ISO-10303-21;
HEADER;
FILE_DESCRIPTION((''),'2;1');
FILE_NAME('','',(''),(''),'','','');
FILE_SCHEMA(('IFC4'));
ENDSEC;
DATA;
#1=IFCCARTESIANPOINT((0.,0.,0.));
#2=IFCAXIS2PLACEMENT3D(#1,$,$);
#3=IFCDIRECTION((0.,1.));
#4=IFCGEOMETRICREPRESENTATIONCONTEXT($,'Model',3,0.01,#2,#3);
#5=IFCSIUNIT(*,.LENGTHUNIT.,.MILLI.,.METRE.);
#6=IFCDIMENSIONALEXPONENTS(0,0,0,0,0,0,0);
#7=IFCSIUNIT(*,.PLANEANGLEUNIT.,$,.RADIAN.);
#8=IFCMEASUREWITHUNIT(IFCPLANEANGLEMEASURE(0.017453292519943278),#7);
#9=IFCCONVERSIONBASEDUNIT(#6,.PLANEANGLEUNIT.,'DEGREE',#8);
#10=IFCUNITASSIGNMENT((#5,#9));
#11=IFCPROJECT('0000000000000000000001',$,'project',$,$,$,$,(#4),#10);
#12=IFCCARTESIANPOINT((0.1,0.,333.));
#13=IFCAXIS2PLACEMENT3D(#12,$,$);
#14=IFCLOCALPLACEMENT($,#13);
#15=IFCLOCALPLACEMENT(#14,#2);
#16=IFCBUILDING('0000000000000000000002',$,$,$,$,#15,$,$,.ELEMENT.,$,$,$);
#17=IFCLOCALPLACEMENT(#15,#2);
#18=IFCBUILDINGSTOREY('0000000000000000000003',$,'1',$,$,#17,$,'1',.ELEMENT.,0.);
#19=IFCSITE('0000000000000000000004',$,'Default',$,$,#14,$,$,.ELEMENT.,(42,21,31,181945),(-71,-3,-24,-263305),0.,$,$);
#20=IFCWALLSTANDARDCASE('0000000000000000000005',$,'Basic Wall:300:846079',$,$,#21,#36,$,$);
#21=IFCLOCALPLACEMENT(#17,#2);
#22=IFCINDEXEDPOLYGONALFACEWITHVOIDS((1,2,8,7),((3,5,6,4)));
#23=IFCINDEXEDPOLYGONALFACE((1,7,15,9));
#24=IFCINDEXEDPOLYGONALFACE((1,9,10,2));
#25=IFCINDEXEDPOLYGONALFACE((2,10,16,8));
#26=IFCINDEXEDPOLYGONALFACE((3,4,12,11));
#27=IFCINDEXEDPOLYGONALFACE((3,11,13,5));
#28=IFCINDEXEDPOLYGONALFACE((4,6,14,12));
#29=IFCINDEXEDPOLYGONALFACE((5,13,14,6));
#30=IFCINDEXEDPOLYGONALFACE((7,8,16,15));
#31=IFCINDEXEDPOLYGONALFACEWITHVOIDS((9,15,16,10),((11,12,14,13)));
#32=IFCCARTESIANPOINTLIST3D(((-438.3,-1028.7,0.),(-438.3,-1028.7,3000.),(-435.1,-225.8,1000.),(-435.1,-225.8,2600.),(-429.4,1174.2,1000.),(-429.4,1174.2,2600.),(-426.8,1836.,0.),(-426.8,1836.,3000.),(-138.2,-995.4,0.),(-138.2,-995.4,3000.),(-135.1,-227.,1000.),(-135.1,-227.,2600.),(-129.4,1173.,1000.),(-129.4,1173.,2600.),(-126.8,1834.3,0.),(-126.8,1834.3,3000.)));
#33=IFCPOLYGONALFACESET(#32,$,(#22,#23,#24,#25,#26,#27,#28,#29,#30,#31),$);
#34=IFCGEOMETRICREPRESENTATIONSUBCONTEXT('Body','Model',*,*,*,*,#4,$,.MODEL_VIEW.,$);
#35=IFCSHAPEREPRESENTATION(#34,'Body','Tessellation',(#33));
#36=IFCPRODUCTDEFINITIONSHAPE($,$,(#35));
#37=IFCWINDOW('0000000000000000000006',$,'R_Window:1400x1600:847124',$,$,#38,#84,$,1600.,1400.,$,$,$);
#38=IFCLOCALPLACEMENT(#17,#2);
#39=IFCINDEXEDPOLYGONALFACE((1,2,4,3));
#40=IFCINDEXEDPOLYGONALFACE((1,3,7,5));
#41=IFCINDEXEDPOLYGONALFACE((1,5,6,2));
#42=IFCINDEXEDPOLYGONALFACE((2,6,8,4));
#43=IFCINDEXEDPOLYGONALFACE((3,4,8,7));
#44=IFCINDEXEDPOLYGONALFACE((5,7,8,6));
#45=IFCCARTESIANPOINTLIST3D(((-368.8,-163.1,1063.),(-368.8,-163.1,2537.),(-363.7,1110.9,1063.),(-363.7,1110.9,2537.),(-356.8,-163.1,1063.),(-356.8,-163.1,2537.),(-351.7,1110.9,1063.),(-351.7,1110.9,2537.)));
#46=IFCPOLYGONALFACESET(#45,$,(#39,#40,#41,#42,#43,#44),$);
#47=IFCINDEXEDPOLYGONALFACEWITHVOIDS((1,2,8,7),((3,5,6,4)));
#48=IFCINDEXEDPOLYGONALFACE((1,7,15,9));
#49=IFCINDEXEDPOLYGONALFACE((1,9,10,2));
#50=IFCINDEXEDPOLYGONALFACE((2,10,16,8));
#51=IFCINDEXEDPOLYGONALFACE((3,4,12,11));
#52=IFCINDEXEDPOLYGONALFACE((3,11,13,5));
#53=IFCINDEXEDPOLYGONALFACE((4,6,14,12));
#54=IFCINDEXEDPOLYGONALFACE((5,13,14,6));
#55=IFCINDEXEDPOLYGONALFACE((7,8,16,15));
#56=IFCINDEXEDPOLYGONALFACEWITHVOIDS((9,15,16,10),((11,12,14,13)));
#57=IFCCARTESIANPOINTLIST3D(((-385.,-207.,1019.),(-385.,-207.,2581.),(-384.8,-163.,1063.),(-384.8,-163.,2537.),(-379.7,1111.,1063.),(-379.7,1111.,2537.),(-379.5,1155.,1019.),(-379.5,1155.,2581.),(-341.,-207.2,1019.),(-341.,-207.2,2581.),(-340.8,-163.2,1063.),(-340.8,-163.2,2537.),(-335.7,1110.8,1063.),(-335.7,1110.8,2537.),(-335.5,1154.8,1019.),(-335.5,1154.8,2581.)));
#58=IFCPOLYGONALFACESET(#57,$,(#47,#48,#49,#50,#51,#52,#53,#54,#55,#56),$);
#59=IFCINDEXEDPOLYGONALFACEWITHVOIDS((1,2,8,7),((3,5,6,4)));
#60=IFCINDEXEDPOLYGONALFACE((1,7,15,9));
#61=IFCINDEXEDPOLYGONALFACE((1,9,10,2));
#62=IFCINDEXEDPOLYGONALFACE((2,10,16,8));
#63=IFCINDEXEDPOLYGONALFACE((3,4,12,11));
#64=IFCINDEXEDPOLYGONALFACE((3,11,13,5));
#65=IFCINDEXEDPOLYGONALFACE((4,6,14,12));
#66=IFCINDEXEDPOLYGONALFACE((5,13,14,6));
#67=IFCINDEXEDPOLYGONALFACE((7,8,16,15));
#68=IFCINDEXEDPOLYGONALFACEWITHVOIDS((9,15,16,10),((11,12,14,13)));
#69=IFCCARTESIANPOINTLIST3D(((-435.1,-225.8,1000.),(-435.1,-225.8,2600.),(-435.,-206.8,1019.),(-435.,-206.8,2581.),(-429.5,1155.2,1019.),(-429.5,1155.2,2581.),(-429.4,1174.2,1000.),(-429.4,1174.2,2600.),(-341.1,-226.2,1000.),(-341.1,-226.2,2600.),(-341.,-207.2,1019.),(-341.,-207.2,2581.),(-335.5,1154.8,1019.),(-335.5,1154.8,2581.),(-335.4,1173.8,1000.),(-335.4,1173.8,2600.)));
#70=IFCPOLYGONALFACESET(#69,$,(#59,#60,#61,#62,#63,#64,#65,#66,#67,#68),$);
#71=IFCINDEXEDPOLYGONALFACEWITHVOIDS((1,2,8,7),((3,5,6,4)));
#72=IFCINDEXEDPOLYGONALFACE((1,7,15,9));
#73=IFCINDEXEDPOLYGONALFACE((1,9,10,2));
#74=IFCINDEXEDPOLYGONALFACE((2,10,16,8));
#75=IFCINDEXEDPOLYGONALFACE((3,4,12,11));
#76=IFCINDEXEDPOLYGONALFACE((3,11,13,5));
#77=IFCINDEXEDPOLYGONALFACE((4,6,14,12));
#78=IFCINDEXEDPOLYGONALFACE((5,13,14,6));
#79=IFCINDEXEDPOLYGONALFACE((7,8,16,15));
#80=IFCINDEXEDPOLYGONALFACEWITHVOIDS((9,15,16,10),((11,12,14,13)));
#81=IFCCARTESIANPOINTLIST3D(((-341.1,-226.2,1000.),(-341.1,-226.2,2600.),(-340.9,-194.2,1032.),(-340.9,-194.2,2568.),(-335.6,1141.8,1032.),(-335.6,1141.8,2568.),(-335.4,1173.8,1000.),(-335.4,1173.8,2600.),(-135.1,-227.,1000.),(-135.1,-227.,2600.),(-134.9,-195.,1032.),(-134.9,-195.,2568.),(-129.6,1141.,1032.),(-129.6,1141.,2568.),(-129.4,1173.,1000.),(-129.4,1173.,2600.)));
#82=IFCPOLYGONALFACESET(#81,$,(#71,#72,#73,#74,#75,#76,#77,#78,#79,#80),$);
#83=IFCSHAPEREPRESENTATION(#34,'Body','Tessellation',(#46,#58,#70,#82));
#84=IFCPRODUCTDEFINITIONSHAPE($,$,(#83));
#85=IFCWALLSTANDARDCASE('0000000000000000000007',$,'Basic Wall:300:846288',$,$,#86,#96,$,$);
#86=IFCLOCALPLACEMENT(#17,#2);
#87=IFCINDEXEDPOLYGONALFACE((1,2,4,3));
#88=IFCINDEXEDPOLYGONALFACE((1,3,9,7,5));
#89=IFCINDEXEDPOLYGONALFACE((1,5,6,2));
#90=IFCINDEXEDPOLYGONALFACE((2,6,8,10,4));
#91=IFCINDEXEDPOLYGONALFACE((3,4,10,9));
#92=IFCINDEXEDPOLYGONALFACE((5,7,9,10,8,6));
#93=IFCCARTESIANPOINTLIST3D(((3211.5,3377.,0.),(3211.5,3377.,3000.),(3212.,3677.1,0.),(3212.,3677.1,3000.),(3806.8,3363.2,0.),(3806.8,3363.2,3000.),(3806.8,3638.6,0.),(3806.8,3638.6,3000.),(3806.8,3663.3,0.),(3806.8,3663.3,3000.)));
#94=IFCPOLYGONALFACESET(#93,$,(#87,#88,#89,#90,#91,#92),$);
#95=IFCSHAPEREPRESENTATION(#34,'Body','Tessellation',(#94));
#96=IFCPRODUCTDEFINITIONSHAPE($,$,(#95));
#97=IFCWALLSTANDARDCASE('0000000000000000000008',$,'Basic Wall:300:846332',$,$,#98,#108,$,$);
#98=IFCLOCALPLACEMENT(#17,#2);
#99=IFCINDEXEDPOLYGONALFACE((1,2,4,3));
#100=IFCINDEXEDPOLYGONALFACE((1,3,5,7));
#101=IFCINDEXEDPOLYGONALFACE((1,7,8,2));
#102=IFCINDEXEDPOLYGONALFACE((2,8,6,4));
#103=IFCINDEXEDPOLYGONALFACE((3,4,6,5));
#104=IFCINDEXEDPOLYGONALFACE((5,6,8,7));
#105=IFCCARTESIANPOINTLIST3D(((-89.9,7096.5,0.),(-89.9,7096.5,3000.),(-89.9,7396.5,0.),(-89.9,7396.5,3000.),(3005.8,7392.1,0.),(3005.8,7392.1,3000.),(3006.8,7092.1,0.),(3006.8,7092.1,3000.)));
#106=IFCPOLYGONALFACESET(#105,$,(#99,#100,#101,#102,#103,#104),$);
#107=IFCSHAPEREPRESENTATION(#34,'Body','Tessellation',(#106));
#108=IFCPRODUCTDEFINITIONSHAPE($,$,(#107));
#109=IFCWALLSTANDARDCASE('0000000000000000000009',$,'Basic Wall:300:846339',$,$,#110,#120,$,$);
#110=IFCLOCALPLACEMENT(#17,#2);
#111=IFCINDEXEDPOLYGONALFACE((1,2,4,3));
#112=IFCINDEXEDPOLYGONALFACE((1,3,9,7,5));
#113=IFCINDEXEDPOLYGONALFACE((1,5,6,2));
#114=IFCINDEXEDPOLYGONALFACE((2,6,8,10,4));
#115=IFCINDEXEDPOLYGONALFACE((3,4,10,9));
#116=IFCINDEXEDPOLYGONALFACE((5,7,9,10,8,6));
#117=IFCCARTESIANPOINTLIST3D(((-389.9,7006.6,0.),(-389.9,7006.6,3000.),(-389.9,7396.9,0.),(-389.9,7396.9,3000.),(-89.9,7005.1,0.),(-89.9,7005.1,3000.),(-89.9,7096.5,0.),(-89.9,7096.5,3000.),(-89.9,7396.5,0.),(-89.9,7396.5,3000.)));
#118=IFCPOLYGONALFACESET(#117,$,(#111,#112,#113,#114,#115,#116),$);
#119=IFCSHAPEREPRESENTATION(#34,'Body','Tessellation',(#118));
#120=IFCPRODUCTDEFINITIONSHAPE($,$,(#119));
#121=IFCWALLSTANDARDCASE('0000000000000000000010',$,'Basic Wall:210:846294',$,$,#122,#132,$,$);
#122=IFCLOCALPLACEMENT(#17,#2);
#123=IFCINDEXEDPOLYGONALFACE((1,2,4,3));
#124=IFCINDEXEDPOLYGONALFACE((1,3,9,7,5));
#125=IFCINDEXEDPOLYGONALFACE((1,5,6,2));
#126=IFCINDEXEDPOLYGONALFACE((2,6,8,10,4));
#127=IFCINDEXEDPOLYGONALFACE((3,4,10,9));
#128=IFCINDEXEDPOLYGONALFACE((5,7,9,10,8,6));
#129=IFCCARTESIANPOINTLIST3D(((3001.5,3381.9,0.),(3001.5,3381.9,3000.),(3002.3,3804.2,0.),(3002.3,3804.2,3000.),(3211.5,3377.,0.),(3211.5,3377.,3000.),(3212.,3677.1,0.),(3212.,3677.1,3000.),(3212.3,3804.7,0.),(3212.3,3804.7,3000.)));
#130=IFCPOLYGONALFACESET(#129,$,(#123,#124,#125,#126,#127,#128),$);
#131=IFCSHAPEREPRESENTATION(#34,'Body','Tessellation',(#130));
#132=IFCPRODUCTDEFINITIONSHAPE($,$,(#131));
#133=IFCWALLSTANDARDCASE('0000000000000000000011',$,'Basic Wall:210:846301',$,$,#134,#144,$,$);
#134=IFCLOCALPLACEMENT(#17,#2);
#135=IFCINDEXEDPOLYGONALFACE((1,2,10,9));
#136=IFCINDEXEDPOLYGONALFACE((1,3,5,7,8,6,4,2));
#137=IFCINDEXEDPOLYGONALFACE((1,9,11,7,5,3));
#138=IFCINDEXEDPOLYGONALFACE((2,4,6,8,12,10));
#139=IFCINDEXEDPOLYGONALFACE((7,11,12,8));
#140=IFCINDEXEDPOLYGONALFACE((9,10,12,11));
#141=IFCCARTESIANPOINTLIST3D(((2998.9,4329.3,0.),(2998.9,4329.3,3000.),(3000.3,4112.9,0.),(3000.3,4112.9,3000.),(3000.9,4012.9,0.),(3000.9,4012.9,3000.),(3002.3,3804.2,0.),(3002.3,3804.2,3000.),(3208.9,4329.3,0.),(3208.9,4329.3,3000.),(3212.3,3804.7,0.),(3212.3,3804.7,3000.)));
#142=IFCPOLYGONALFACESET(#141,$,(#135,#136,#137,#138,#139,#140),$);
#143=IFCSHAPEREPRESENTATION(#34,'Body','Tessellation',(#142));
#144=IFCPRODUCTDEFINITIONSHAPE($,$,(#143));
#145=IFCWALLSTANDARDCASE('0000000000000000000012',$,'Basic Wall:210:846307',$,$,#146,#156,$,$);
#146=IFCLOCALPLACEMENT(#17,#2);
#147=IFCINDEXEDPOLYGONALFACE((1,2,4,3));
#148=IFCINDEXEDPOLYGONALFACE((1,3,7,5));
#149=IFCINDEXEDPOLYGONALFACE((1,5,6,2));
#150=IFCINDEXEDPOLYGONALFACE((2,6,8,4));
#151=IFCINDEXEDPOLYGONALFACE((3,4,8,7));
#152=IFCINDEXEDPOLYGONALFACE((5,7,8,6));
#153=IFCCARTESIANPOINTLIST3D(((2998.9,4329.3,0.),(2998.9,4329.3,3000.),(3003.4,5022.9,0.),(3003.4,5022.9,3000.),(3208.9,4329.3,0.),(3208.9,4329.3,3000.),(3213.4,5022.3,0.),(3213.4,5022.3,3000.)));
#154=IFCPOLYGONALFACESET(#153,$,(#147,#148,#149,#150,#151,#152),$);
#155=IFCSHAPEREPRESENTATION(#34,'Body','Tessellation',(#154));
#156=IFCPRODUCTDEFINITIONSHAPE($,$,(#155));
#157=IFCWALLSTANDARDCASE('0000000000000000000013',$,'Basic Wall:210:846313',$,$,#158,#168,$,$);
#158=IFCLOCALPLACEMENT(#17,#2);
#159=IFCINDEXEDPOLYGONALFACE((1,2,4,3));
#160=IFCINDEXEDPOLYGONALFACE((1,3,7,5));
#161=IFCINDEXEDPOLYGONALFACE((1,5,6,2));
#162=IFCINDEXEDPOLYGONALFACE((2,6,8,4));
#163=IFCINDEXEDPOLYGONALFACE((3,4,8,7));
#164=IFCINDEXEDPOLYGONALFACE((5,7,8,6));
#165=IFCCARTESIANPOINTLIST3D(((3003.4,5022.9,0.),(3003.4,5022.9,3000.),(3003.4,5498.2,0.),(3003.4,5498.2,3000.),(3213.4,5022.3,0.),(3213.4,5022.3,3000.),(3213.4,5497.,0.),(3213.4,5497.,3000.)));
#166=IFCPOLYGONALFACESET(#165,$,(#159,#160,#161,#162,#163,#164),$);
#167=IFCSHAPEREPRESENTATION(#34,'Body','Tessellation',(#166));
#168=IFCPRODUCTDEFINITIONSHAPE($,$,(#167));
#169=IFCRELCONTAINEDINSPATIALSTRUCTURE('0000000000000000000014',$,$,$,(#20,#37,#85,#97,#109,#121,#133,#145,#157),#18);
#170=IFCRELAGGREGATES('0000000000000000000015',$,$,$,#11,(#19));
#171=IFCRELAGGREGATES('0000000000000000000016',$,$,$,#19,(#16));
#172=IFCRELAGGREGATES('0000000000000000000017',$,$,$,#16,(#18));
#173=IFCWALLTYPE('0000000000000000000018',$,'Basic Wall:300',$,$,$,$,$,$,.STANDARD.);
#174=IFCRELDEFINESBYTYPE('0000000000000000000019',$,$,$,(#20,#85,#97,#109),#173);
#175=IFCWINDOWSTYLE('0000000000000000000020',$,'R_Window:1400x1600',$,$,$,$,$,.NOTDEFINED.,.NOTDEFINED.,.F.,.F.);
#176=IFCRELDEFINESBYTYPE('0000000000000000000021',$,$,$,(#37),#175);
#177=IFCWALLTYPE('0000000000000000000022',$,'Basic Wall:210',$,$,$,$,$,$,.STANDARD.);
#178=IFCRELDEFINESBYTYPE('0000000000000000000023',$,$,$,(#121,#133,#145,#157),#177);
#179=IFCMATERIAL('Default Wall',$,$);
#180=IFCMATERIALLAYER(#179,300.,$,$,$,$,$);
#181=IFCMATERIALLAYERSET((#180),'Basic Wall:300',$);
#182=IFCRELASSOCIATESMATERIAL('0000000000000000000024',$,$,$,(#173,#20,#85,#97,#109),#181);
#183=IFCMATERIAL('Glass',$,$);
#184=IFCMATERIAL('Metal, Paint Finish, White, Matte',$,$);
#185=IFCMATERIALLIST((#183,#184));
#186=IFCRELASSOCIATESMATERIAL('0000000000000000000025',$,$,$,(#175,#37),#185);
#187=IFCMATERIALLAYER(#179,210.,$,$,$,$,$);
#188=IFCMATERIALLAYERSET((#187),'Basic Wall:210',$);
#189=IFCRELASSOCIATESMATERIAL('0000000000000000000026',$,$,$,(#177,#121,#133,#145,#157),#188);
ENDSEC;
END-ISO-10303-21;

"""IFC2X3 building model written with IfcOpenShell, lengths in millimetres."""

from ifc_helpers import new_model, entity, si_unit, converted_unit, direction, frame, frame_2d, origin, place, context, subcontext, project, spatial, polyline, rectangle, outline, extrude, source, transform, mapped, material, material_list, layer, layer_set, layer_usage, type_object, type_shapes, element, fill, save


model = new_model("IFC2X3")

# Units and contexts
model_context = context("Model", 3, precision=0.01, world=origin(), true_north=direction((0.0, 1.0)))
body_context = subcontext(model_context, "Body", "Model", "MODEL_VIEW")
ifc_project = project(units=[si_unit("LENGTHUNIT", "METRE", prefix="MILLI"), converted_unit("PLANEANGLEUNIT", "DEGREE", entity("IfcPlaneAngleMeasure", 0.017453292519943278), si_unit("PLANEANGLEUNIT", "RADIAN"), dimensions=[0, 0, 0, 0, 0, 0, 0])], contexts=[model_context])

# Site, building, storey
site_placement = place(None, frame((0.1, 0.0, 333.0)))
site = spatial("IfcSite", under=ifc_project, at=site_placement, Name="Default", CompositionType="ELEMENT", RefLatitude=(42, 21, 31, 181945), RefLongitude=(-71, -3, -24, -263305), RefElevation=0.0)
building_placement = place(site_placement, origin())
building = spatial("IfcBuilding", under=site, at=building_placement, CompositionType="ELEMENT")
storey_placement = place(building_placement, origin())
storey = spatial("IfcBuildingStorey", under=building, at=storey_placement, Name="1", LongName="1", CompositionType="ELEMENT", Elevation=0.0)

# Shared definitions
ifc_material_1 = material(Name="Default Wall")
ifc_layer_1 = layer(ifc_material_1, 300.0)
ifc_layer_set_1 = layer_set([ifc_layer_1], Name="Basic Wall:300")
wall_type_1 = type_object("IfcWallType", Name="Basic Wall:300", PredefinedType="STANDARD", material=ifc_layer_set_1)
ifc_material_2 = material(Name="Glass")
ifc_material_3 = material(Name="Metal, Paint Finish, White, Matte")
ifc_material_list_1 = material_list([ifc_material_2, ifc_material_3])
window_style = type_object("IfcWindowStyle", Name="R_Window:1400x1600", ConstructionType="NOTDEFINED", OperationType="NOTDEFINED", ParameterTakesPrecedence=False, Sizeable=False, material=ifc_material_list_1)
shared_shape_1 = source(origin(), body_context, "Body", "SweptSolid", [
    extrude(rectangle(XDim=12.0, YDim=1274.0, at=frame_2d((0.0, 0.0), x_axis=(1.0, 0.0))), frame((700.0, 228.0, 63.0), z_axis=(0.0, 0.0, 1.0), x_axis=(0.0, -1.0, 0.0)), (0.0, 0.0, 1.0), 1474.0),
    extrude(outline(polyline([(-681.0, -781.0), (681.0, -781.0), (681.0, 781.0), (-681.0, 781.0), (-681.0, -781.0)]), holes=[polyline([(-637.0, -737.0), (-637.0, 737.0), (637.0, 737.0), (637.0, -737.0), (-637.0, -737.0)])]), frame((700.0, 206.0, 800.0), z_axis=(0.0, 1.0, 0.0), x_axis=(1.0, 0.0, 0.0)), (0.0, 0.0, 1.0), 44.0),
    extrude(outline(polyline([(-700.0, -800.0), (700.0, -800.0), (700.0, 800.0), (-700.0, 800.0), (-700.0, -800.0)]), holes=[polyline([(-681.0, -781.0), (-681.0, 781.0), (681.0, 781.0), (681.0, -781.0), (-681.0, -781.0)])]), frame((700.0, 206.0, 800.0), z_axis=(0.0, 1.0, 0.0), x_axis=(1.0, 0.0, 0.0)), (0.0, 0.0, 1.0), 94.0),
    extrude(outline(polyline([(-700.0, -800.0), (700.0, -800.0), (700.0, 800.0), (-700.0, 800.0), (-700.0, -800.0)]), holes=[polyline([(-668.0, -768.0), (-668.0, 768.0), (668.0, 768.0), (668.0, -768.0), (-668.0, -768.0)])]), frame((700.0, 0.0, 800.0), z_axis=(0.0, 1.0, 0.0), x_axis=(1.0, 0.0, 0.0)), (0.0, 0.0, 1.0), 206.0),
])
type_shapes(window_style, [shared_shape_1])

# Wall, opening, window
ifc_layer_usage_1 = layer_usage(ifc_layer_set_1, "AXIS2", "NEGATIVE", 150.0)
wall_1_placement = place(storey_placement, frame((-288.3, -1029.3, 0.0), z_axis=(0.0, 0.0, 1.0), x_axis=(0.004036, 0.999992, 0.0)))
wall_1 = element("IfcWallStandardCase", 1, at=wall_1_placement, inside=storey, type_object=wall_type_1, material=ifc_layer_usage_1, Name="Basic Wall:300:846079", context=body_context, shape_type="SweptSolid", body=[
    extrude(outline(polyline([(2864.2, -150.0), (2864.7, 150.0), (0.0, 150.0), (34.5, -150.0), (336.5, -150.0), (2864.2, -150.0)])), origin(), (0.0, 0.0, 1.0), 3000.0),
])
opening_1_placement = place(wall_1_placement, frame((802.9, -150.0, 1000.0)))
opening_1 = element("IfcOpeningElement", 2, at=opening_1_placement, cuts=wall_1, ObjectType="Opening", context=body_context, shape_type="SweptSolid", body=[
    extrude(rectangle(XDim=1600.0, YDim=1400.0, at=frame_2d((800.0, 700.0), x_axis=(1.0, 0.0))), frame((0.0, 0.0, 0.0), z_axis=(0.0, 1.0, 0.0), x_axis=(0.0, 0.0, 1.0)), (0.0, 0.0, 1.0), 300.0),
])
window_1_placement = place(opening_1_placement, origin())
window_1 = element("IfcWindow", 3, at=window_1_placement, inside=storey, type_object=window_style, material=ifc_material_list_1, Name="R_Window:1400x1600:847124", OverallHeight=1600.0, OverallWidth=1400.0, context=body_context, shape_type="MappedRepresentation", body=[
    mapped(shared_shape_1, transform((0.0, 0.0, 0.0), scale=1.0)),
])
fill(opening_1, window_1)

# Walls
ifc_layer_usage_2 = layer_usage(ifc_layer_set_1, "AXIS2", "NEGATIVE", 150.0)
wall_2_placement = place(storey_placement, frame((3208.5, 3527.1, 0.0), z_axis=(0.0, 0.0, 1.0), x_axis=(0.999732, -0.023142, 0.0)))
element("IfcWallStandardCase", 4, at=wall_2_placement, inside=storey, type_object=wall_type_1, material=ifc_layer_usage_2, Name="Basic Wall:300:846288", context=body_context, shape_type="SweptSolid", body=[
    extrude(outline(polyline([(601.9, -150.0), (595.5, 125.3), (594.9, 150.0), (0.0, 150.0), (6.4, -150.0), (601.9, -150.0)])), origin(), (0.0, 0.0, 1.0), 3000.0),
])
ifc_layer_usage_3 = layer_usage(ifc_layer_set_1, "AXIS2", "NEGATIVE", 150.0)
wall_3_placement = place(storey_placement, frame((-90.1, 7246.5, 0.0), z_axis=(0.0, 0.0, 1.0), x_axis=(0.999999, -0.001405, 0.0)))
element("IfcWallStandardCase", 5, at=wall_3_placement, inside=storey, type_object=wall_type_1, material=ifc_layer_usage_3, Name="Basic Wall:300:846332", context=body_context, shape_type="SweptSolid", body=[
    extrude(outline(polyline([(3097.2, -150.0), (3095.7, 150.0), (0.0, 150.0), (0.4, -150.0), (3097.2, -150.0)])), origin(), (0.0, 0.0, 1.0), 3000.0),
])
ifc_layer_usage_4 = layer_usage(ifc_layer_set_1, "AXIS2", "NEGATIVE", 150.0)
wall_4_placement = place(storey_placement, frame((-239.9, 7005.1, 0.0), z_axis=(0.0, 0.0, 1.0), x_axis=(0.0, 1.0, 0.0)))
element("IfcWallStandardCase", 6, at=wall_4_placement, inside=storey, type_object=wall_type_1, material=ifc_layer_usage_4, Name="Basic Wall:300:846339", context=body_context, shape_type="SweptSolid", body=[
    extrude(outline(polyline([(391.4, -150.0), (391.8, 150.0), (1.5, 150.0), (0.0, -150.0), (91.4, -150.0), (391.4, -150.0)])), origin(), (0.0, 0.0, 1.0), 3000.0),
])
ifc_layer_2 = layer(ifc_material_1, 210.0)
ifc_layer_set_2 = layer_set([ifc_layer_2], Name="Basic Wall:210")
ifc_layer_usage_5 = layer_usage(ifc_layer_set_2, "AXIS2", "NEGATIVE", 105.0)
wall_type_2 = type_object("IfcWallType", Name="Basic Wall:210", PredefinedType="STANDARD", material=ifc_layer_set_2)
wall_5_placement = place(storey_placement, frame((3107.3, 3804.9, 0.0), z_axis=(0.0, 0.0, 1.0), x_axis=(-0.001842, -0.999998, 0.0)))
element("IfcWallStandardCase", 7, at=wall_5_placement, inside=storey, type_object=wall_type_2, material=ifc_layer_usage_5, Name="Basic Wall:210:846294", context=body_context, shape_type="SweptSolid", body=[
    extrude(outline(polyline([(423.2, -105.0), (427.7, 105.0), (127.6, 105.0), (0.0, 105.0), (0.9, -105.0), (423.2, -105.0)])), origin(), (0.0, 0.0, 1.0), 3000.0),
])
ifc_layer_usage_6 = layer_usage(ifc_layer_set_2, "AXIS2", "NEGATIVE", 105.0)
wall_6_placement = place(storey_placement, frame((3103.9, 4330.0, 0.0), z_axis=(0.0, 0.0, 1.0), x_axis=(0.006465, -0.999979, 0.0)))
element("IfcWallStandardCase", 8, at=wall_6_placement, inside=storey, type_object=wall_type_2, material=ifc_layer_usage_6, Name="Basic Wall:210:846301", context=body_context, shape_type="SweptSolid", body=[
    extrude(outline(polyline([(525.1, -105.0), (525.9, 105.0), (1.4, 105.0), (0.0, -105.0), (216.4, -105.0), (316.4, -105.0), (525.1, -105.0)])), origin(), (0.0, 0.0, 1.0), 3000.0),
])
ifc_layer_usage_7 = layer_usage(ifc_layer_set_2, "AXIS2", "NEGATIVE", 105.0)
wall_7_placement = place(storey_placement, frame((3108.4, 5022.9, 0.0), z_axis=(0.0, 0.0, 1.0), x_axis=(-0.006525, -0.999979, 0.0)))
element("IfcWallStandardCase", 9, at=wall_7_placement, inside=storey, type_object=wall_type_2, material=ifc_layer_usage_7, Name="Basic Wall:210:846307", context=body_context, shape_type="SweptSolid", body=[
    extrude(outline(polyline([(694.4, -105.0), (693.0, 105.0), (0.0, 105.0), (0.7, -105.0), (694.4, -105.0)])), origin(), (0.0, 0.0, 1.0), 3000.0),
])
ifc_layer_usage_8 = layer_usage(ifc_layer_set_2, "AXIS2", "NEGATIVE", 105.0)
wall_8_placement = place(storey_placement, frame((3108.4, 5498.2, 0.0), z_axis=(0.0, 0.0, 1.0), x_axis=(0.0, -1.0, 0.0)))
element("IfcWallStandardCase", 10, at=wall_8_placement, inside=storey, type_object=wall_type_2, material=ifc_layer_usage_8, Name="Basic Wall:210:846313", context=body_context, shape_type="SweptSolid", body=[
    extrude(outline(polyline([(475.3, -105.0), (475.9, 105.0), (1.2, 105.0), (0.0, -105.0), (475.3, -105.0)])), origin(), (0.0, 0.0, 1.0), 3000.0),
])

save(model, "model.ifc")
